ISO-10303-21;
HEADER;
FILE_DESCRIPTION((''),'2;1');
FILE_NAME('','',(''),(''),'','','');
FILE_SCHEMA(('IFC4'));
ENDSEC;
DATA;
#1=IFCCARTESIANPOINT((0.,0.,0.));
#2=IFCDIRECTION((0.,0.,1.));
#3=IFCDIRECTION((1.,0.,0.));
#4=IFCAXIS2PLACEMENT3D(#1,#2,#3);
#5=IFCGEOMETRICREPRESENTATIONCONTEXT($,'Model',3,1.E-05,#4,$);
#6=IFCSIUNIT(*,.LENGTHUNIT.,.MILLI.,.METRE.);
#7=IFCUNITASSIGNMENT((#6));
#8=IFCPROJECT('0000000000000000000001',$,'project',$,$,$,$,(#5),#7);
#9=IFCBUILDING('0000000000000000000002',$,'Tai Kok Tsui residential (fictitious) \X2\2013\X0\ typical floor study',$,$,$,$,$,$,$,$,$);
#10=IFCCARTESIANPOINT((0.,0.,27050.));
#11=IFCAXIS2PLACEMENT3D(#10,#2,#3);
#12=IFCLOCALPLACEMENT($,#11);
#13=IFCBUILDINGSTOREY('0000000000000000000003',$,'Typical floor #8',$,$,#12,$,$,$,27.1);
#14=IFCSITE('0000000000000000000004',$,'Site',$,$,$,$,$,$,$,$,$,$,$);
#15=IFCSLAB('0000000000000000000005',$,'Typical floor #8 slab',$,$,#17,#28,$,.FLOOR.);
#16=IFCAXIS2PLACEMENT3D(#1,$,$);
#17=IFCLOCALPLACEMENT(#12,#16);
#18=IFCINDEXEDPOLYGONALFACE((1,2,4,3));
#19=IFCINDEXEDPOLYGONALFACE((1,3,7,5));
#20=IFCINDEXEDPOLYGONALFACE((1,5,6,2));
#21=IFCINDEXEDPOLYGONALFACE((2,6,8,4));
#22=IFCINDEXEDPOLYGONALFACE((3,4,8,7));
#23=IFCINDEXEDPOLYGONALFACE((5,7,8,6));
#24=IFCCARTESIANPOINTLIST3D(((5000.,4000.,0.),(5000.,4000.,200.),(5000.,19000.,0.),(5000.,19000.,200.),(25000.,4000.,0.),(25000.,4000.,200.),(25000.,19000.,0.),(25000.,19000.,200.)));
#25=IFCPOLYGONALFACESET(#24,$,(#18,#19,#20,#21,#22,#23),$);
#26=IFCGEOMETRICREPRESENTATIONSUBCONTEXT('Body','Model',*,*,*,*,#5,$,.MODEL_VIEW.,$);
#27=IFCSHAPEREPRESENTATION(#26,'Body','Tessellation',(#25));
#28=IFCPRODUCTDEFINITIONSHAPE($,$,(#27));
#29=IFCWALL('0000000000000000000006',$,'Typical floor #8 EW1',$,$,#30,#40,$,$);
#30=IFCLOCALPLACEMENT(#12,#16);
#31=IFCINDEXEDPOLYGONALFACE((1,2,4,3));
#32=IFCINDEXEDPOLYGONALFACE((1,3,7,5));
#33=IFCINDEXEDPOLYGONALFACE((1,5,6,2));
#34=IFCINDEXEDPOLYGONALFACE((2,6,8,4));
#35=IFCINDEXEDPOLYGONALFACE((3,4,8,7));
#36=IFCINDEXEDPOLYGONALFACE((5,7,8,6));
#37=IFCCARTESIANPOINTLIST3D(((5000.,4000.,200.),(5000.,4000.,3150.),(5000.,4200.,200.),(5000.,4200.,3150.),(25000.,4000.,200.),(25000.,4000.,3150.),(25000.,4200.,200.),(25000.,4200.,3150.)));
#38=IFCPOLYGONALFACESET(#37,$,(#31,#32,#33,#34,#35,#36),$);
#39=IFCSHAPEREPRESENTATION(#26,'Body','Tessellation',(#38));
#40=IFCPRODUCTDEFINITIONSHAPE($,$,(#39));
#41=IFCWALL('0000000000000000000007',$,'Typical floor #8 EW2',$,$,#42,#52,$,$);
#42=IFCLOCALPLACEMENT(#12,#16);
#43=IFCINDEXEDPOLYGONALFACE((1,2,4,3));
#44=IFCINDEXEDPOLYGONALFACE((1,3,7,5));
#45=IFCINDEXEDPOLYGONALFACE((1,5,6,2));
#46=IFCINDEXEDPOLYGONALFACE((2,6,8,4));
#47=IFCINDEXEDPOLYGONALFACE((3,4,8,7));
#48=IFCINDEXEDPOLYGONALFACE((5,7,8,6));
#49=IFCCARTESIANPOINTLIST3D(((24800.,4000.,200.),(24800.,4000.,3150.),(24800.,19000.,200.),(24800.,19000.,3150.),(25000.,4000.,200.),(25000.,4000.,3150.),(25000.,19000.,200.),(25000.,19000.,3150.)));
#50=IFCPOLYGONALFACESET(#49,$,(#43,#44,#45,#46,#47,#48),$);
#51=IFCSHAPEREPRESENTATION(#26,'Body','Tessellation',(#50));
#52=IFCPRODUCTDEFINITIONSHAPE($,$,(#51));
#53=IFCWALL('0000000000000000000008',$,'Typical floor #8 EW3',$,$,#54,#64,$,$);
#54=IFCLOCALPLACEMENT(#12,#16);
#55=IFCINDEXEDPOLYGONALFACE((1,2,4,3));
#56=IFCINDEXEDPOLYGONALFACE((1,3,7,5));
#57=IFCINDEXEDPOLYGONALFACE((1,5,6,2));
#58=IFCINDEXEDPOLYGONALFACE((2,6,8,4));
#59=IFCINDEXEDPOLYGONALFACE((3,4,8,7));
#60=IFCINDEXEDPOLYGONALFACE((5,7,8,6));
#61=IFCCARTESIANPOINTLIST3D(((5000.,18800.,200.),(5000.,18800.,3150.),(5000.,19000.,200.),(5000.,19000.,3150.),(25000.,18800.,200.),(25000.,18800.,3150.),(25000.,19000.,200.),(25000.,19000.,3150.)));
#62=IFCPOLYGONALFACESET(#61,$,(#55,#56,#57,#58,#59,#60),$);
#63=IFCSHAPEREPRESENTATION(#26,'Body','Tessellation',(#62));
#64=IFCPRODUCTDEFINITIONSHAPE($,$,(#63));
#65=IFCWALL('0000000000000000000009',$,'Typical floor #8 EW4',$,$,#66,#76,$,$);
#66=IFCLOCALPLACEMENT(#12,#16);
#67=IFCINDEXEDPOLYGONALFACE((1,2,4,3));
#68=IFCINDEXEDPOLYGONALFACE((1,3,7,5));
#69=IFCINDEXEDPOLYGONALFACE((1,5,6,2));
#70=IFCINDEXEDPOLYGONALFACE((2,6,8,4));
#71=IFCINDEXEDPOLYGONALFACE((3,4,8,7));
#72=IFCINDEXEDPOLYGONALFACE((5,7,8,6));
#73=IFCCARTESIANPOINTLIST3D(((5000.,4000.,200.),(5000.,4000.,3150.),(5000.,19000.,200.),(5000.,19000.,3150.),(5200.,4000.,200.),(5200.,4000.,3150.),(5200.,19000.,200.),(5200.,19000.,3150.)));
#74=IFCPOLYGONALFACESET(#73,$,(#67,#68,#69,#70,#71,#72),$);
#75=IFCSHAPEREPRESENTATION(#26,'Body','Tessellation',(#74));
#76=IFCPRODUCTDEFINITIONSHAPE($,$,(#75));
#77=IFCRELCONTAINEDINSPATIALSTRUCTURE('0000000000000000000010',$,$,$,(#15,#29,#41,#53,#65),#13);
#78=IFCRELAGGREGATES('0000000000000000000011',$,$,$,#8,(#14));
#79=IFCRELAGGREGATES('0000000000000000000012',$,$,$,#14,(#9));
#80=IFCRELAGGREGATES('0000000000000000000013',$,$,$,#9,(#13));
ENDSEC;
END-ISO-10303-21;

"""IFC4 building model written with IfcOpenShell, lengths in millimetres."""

from ifc_helpers import new_model, si_unit, frame, origin_with_axes, place, context, subcontext, project, spatial, indexed_curve, outline, extrude, element, save


model = new_model("IFC4")

# Units and contexts
model_context = context("Model", 3, precision=1e-05, world=origin_with_axes())
body_context = subcontext(model_context, "Body", "Model", "MODEL_VIEW")
ifc_project = project(units=[si_unit("LENGTHUNIT", "METRE", prefix="MILLI")], contexts=[model_context])

# Site, building, storey
site = spatial("IfcSite", under=ifc_project, Name="Site")
building = spatial("IfcBuilding", under=site, Name="Tai Kok Tsui residential (fictitious) – typical floor study")
storey_placement = place(None, frame((0.0, 0.0, 27050.0), z_axis=(0.0, 0.0, 1.0), x_axis=(1.0, 0.0, 0.0)))
storey = spatial("IfcBuildingStorey", under=building, at=storey_placement, Name="Typical floor #8", Elevation=27.1)

# Slab
slab_placement = place(storey_placement, origin_with_axes())
element("IfcSlab", 1, at=slab_placement, inside=storey, Name="Typical floor #8 slab", PredefinedType="FLOOR", context=body_context, shape_type="SweptSolid", body=[
    extrude(outline(indexed_curve([(5000.0, 4000.0), (25000.0, 4000.0), (25000.0, 19000.0), (5000.0, 19000.0)])), None, (0.0, 0.0, 1.0), 200.0),
])

# Walls
wall_1_placement = place(storey_placement, frame((5000.0, 4000.0, 200.0), z_axis=(0.0, 0.0, 1.0), x_axis=(1.0, 0.0, 0.0)))
element("IfcWall", 2, at=wall_1_placement, inside=storey, Name="Typical floor #8 EW1", context=body_context, shape_type="SweptSolid", body=[
    extrude(outline(indexed_curve([(0.0, 0.0), (0.0, 200.0), (20000.0, 200.0), (20000.0, 0.0), (0.0, 0.0)], self_intersect=False)), origin_with_axes(), (0.0, 0.0, 1.0), 2950.0),
])
wall_2_placement = place(storey_placement, frame((25000.0, 4000.0, 200.0), z_axis=(0.0, 0.0, 1.0), x_axis=(0.0, 1.0, 0.0)))
element("IfcWall", 3, at=wall_2_placement, inside=storey, Name="Typical floor #8 EW2", context=body_context, shape_type="SweptSolid", body=[
    extrude(outline(indexed_curve([(0.0, 0.0), (0.0, 200.0), (15000.0, 200.0), (15000.0, 0.0), (0.0, 0.0)], self_intersect=False)), origin_with_axes(), (0.0, 0.0, 1.0), 2950.0),
])
wall_3_placement = place(storey_placement, frame((25000.0, 19000.0, 200.0), z_axis=(0.0, 0.0, 1.0), x_axis=(-1.0, 0.0, 0.0)))
element("IfcWall", 4, at=wall_3_placement, inside=storey, Name="Typical floor #8 EW3", context=body_context, shape_type="SweptSolid", body=[
    extrude(outline(indexed_curve([(0.0, 0.0), (0.0, 200.0), (20000.0, 200.0), (20000.0, 0.0), (0.0, 0.0)], self_intersect=False)), origin_with_axes(), (0.0, 0.0, 1.0), 2950.0),
])
wall_4_placement = place(storey_placement, frame((5000.0, 19000.0, 200.0), z_axis=(0.0, 0.0, 1.0), x_axis=(0.0, -1.0, 0.0)))
element("IfcWall", 5, at=wall_4_placement, inside=storey, Name="Typical floor #8 EW4", context=body_context, shape_type="SweptSolid", body=[
    extrude(outline(indexed_curve([(0.0, 0.0), (0.0, 200.0), (15000.0, 200.0), (15000.0, 0.0), (0.0, 0.0)], self_intersect=False)), origin_with_axes(), (0.0, 0.0, 1.0), 2950.0),
])

save(model, "model.ifc")
